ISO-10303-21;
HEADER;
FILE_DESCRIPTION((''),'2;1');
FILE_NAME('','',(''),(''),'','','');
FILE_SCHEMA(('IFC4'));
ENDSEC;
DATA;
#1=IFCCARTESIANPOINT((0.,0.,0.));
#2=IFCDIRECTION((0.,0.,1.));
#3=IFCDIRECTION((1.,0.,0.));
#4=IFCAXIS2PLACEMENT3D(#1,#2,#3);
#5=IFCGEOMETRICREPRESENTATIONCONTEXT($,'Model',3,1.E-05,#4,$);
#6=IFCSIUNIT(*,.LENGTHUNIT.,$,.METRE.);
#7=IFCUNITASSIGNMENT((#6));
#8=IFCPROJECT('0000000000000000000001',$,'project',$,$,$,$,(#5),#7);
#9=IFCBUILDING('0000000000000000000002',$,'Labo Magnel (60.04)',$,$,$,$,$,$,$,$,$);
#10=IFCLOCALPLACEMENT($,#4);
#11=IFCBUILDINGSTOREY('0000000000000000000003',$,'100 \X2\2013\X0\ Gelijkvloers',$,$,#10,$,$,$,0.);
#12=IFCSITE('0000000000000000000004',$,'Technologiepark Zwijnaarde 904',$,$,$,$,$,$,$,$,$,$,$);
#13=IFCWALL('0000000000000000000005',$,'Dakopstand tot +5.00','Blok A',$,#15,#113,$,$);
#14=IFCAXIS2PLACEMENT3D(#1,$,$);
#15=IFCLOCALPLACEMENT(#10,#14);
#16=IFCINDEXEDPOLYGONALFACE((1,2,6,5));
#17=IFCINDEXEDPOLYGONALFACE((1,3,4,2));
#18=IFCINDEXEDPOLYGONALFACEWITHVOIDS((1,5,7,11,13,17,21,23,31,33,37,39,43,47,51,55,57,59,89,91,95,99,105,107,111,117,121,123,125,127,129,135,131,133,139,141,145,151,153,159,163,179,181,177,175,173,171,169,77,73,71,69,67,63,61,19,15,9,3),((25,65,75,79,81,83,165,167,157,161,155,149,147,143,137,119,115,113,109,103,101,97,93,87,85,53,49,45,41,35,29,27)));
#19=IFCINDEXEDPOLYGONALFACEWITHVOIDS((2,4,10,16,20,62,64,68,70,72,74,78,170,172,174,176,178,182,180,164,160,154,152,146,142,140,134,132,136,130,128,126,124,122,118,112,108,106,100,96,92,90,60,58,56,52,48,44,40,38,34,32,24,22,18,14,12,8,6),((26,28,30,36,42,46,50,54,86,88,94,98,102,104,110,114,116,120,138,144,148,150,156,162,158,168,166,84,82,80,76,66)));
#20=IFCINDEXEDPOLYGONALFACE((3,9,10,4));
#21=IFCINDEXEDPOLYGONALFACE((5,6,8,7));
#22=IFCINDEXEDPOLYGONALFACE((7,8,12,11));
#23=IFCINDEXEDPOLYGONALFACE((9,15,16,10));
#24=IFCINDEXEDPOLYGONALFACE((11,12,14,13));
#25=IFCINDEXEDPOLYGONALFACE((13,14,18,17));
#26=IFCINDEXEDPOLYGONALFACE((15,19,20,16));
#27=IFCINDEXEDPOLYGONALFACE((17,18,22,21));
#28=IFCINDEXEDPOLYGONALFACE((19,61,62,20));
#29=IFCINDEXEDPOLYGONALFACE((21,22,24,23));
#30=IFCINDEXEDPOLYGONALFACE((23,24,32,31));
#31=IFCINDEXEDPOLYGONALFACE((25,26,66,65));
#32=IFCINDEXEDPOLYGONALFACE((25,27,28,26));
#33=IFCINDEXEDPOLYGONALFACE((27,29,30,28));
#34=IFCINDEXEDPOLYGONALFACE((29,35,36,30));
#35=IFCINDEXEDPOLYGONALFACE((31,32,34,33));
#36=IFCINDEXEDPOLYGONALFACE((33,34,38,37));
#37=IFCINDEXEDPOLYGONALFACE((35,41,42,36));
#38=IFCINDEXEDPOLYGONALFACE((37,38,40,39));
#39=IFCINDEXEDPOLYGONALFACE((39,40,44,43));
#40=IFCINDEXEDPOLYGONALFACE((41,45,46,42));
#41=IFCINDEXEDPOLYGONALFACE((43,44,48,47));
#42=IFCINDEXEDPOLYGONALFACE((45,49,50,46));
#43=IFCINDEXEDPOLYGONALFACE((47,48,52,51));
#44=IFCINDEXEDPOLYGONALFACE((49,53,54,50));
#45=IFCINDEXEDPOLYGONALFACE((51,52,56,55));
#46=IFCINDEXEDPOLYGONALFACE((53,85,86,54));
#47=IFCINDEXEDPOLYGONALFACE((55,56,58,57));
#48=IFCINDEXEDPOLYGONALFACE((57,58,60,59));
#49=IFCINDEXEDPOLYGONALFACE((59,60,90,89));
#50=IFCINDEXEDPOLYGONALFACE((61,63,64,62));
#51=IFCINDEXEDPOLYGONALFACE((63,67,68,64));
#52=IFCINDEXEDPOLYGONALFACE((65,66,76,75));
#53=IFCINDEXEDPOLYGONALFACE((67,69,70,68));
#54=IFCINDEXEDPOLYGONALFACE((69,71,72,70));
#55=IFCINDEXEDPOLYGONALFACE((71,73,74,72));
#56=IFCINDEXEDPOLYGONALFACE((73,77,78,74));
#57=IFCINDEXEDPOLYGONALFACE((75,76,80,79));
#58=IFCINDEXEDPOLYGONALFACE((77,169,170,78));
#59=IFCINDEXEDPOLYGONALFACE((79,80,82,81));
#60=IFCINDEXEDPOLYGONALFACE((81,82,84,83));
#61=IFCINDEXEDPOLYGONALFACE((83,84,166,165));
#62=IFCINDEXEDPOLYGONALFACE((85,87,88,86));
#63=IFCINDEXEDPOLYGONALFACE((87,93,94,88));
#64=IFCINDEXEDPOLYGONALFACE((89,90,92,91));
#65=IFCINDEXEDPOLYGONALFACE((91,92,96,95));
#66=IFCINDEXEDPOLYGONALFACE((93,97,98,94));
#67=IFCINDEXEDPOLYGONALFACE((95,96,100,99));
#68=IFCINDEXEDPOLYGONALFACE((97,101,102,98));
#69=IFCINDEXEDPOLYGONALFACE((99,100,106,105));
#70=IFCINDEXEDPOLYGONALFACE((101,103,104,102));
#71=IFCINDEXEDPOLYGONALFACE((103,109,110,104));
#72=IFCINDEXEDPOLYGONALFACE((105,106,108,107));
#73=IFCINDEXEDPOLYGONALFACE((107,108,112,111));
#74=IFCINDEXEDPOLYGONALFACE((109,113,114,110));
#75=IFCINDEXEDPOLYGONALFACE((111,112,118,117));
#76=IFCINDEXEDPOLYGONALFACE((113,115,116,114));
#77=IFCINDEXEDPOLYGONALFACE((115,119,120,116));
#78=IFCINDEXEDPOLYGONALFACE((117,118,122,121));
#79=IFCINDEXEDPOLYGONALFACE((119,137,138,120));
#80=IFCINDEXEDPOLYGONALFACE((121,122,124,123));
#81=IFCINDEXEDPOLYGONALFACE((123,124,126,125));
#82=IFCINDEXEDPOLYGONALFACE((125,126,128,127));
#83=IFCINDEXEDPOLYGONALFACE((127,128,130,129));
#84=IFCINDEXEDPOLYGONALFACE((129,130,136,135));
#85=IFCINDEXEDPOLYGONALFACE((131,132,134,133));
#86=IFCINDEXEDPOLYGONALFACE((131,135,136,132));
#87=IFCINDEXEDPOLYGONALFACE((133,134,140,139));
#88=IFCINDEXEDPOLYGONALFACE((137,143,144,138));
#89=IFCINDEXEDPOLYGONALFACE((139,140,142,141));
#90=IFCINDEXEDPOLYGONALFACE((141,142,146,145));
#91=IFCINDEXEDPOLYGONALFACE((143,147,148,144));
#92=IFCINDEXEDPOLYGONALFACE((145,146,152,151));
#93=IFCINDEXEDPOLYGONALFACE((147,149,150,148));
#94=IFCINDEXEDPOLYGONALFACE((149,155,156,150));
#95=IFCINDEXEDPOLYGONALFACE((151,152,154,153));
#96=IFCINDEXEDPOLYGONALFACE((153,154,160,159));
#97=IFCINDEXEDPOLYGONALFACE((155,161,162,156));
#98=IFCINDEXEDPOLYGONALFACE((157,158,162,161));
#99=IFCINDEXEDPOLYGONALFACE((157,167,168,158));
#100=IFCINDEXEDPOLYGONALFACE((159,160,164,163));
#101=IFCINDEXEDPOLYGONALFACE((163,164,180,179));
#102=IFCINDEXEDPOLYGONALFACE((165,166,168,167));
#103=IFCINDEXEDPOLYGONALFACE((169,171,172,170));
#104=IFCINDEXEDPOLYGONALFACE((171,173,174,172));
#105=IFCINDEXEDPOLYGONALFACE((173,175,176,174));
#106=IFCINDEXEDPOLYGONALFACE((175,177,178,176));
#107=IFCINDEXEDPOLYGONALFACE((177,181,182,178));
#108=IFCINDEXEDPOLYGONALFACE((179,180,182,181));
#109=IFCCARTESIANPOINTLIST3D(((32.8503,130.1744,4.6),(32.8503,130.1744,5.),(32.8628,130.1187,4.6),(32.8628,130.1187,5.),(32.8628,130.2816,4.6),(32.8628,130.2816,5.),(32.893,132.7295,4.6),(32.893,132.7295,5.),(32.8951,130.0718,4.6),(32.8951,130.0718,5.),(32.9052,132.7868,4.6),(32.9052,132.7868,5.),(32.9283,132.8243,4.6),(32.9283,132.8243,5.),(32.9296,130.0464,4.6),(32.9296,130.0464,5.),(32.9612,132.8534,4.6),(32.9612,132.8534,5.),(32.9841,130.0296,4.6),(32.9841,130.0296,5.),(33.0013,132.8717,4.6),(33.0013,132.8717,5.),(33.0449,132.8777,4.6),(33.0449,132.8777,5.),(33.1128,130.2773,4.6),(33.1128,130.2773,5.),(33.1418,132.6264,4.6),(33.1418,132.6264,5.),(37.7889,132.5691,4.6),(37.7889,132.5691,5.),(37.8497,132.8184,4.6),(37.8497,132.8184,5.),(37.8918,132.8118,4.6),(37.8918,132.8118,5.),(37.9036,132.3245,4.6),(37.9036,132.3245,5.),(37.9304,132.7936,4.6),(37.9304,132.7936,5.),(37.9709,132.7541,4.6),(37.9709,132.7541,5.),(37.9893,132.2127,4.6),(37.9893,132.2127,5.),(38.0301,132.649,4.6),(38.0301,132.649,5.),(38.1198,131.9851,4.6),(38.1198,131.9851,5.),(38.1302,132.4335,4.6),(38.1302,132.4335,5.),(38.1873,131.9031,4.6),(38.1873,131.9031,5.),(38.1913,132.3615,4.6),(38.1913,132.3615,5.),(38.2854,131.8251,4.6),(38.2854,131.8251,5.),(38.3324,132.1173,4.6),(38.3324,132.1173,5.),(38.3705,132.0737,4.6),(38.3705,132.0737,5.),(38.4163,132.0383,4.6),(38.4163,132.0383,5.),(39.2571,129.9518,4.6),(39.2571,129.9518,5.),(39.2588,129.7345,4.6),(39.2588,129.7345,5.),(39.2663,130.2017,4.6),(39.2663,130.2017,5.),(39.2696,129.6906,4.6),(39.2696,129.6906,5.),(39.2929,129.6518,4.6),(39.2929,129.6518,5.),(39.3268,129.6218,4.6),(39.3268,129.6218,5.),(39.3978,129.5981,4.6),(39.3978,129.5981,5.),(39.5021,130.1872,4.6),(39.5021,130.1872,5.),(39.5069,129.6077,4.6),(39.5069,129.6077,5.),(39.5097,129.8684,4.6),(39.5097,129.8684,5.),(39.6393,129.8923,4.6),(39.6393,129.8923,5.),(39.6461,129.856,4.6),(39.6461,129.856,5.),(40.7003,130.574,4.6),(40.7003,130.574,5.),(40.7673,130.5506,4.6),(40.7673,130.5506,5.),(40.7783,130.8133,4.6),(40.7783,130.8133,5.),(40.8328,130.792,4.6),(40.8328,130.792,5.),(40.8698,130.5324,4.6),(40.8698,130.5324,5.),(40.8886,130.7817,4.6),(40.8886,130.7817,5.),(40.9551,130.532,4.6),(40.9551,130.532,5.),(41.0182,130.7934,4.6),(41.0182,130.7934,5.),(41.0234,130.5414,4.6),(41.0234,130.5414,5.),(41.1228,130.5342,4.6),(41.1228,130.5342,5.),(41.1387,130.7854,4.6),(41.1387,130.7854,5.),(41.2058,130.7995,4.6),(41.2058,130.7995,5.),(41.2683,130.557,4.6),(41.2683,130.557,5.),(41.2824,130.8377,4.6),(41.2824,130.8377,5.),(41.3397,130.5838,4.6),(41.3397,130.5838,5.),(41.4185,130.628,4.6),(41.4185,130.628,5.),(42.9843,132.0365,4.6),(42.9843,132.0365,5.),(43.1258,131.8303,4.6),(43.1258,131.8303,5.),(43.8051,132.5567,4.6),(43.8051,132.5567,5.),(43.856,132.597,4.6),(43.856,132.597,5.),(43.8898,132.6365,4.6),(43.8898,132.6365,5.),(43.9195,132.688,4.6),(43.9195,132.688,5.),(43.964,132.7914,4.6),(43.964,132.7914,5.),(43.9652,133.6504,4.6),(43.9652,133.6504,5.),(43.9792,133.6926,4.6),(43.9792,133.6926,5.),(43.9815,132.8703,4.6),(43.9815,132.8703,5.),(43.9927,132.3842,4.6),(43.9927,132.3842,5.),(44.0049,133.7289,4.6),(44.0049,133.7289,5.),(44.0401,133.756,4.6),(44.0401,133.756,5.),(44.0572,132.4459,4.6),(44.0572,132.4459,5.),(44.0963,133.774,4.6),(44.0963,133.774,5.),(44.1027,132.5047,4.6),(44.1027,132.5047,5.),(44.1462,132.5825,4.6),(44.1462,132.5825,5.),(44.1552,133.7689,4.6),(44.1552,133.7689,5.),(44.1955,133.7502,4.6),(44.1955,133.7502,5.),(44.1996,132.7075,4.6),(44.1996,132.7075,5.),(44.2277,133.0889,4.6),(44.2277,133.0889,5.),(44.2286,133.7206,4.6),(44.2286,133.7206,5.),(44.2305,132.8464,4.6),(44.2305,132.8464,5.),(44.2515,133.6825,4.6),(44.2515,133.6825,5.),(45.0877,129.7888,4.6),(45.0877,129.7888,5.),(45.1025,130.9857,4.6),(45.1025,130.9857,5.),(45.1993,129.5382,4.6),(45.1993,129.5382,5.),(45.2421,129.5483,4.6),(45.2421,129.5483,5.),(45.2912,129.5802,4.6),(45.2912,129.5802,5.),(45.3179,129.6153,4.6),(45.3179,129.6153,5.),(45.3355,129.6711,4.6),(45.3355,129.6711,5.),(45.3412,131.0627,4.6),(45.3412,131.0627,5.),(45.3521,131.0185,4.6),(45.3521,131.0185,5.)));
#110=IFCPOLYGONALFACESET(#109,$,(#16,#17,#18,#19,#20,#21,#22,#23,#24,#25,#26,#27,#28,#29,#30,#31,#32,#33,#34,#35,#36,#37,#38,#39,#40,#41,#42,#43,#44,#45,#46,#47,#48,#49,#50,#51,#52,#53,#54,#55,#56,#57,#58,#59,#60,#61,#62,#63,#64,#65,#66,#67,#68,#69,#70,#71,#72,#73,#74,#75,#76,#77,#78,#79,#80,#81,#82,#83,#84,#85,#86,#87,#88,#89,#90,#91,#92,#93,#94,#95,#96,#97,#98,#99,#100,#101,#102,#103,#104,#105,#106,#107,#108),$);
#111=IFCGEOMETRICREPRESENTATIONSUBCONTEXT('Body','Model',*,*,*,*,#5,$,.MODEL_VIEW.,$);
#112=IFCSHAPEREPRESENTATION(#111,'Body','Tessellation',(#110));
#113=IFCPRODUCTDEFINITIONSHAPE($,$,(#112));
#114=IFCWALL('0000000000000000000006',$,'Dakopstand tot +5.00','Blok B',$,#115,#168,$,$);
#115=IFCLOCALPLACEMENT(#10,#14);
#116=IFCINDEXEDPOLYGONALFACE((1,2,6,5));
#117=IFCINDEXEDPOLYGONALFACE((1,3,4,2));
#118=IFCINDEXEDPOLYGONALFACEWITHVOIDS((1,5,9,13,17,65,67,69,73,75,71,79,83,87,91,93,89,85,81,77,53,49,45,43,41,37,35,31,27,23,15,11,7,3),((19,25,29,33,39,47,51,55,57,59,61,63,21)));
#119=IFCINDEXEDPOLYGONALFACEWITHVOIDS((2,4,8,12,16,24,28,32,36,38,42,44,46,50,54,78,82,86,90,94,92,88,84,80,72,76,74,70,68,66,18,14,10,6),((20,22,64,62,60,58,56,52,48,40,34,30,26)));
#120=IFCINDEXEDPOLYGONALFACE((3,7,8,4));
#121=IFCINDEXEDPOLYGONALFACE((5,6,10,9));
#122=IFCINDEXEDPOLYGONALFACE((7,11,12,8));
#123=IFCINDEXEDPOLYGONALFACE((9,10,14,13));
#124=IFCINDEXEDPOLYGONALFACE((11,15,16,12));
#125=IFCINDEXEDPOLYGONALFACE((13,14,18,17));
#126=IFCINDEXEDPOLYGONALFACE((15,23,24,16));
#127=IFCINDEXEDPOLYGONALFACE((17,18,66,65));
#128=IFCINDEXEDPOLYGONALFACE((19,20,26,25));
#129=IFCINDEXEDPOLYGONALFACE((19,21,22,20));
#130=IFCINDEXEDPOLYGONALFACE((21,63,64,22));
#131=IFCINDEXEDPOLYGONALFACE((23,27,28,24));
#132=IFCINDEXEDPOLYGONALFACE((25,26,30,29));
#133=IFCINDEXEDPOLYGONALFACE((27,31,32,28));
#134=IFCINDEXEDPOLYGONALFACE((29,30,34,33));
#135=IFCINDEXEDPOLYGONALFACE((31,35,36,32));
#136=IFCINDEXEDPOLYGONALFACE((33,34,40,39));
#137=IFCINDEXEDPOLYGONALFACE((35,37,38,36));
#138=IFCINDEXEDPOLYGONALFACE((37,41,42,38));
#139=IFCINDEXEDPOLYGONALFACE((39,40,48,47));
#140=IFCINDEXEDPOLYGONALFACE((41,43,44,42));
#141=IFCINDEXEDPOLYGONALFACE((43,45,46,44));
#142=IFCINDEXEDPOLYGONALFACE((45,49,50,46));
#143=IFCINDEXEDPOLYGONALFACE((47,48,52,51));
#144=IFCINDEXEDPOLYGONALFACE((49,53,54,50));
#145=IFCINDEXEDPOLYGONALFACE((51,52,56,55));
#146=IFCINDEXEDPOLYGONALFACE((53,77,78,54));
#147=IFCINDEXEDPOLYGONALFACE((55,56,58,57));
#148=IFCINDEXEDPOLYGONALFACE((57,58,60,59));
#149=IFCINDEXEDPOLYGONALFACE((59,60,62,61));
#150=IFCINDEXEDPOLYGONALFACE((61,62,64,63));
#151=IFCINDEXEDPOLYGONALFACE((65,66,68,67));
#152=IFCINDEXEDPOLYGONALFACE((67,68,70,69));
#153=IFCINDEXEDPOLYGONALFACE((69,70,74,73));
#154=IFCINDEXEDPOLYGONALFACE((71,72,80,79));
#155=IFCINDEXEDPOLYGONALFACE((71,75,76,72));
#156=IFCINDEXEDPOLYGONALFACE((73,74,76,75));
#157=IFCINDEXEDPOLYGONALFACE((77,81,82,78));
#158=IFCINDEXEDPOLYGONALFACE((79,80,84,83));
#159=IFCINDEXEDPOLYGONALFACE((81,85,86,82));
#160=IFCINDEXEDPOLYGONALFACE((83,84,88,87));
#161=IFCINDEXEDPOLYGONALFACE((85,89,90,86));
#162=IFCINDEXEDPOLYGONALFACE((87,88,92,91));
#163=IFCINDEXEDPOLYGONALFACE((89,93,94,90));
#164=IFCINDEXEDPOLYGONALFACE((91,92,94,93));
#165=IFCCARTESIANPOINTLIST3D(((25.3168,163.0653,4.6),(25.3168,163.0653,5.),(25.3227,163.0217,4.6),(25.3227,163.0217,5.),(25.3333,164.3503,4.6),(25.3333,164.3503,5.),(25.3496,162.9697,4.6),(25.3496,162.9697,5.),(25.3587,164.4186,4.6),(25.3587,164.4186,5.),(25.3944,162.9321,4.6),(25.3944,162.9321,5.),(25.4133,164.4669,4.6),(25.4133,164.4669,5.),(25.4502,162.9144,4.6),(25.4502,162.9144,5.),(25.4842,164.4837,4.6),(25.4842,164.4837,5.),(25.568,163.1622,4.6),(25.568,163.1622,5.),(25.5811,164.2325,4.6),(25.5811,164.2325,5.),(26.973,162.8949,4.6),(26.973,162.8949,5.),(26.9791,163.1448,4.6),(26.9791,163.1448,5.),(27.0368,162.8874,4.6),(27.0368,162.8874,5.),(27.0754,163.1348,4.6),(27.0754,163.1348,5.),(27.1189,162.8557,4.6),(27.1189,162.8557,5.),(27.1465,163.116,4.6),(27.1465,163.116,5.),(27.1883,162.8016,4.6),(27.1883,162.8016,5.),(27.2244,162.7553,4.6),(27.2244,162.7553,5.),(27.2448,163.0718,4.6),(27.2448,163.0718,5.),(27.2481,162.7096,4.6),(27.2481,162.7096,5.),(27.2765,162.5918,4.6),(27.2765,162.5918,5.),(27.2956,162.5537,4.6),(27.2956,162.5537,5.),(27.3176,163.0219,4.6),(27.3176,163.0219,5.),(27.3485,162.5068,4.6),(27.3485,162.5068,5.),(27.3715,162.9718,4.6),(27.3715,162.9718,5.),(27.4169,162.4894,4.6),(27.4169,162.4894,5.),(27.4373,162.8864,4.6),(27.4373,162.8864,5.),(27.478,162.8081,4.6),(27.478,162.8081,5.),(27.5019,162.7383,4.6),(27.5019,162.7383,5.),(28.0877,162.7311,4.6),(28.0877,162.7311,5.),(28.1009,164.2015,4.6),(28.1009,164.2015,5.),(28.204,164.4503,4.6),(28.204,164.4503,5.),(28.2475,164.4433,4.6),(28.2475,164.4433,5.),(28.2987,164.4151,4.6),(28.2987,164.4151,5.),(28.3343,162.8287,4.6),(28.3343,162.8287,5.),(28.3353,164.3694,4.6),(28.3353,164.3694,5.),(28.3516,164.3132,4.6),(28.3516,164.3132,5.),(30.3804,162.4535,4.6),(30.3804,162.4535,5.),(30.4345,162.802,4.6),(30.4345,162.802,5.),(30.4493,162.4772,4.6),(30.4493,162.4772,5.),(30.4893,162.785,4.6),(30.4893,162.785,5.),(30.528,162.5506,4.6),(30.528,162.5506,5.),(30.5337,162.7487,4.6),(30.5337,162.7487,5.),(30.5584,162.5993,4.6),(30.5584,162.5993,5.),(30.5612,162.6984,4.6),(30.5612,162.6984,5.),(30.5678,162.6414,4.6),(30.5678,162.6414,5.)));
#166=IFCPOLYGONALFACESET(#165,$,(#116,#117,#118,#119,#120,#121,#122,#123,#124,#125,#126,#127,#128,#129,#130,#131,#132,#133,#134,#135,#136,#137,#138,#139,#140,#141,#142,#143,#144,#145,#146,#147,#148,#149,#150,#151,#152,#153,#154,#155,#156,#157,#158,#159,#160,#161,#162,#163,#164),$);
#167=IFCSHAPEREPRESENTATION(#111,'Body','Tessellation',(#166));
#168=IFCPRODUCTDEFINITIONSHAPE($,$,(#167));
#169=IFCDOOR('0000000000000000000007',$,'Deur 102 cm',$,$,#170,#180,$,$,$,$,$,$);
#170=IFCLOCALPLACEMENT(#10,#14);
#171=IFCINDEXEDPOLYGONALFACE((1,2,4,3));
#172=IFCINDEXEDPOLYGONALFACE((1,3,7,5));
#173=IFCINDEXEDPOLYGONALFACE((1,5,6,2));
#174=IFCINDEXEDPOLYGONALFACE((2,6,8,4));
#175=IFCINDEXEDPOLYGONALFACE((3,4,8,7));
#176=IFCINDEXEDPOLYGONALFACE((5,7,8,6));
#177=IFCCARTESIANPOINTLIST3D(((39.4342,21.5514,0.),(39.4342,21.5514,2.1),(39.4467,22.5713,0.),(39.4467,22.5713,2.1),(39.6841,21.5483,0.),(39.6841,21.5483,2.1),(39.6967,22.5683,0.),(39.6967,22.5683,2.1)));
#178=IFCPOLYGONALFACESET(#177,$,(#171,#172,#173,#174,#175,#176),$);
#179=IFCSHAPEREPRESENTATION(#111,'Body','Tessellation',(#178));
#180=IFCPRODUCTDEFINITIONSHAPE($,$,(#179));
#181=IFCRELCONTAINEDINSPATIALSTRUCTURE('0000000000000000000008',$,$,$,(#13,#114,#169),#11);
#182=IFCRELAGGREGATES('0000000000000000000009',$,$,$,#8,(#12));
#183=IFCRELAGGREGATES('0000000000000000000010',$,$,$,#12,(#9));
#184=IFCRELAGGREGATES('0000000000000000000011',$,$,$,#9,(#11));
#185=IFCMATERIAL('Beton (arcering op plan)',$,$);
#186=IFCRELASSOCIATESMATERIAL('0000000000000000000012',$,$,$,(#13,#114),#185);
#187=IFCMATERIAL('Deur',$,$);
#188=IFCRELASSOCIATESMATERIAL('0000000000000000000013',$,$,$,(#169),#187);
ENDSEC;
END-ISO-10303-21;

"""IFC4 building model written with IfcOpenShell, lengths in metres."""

from ifc_helpers import new_model, si_unit, frame, origin, origin_with_axes, place, context, subcontext, project, spatial, polyline, outline, extrude, material, element, save


model = new_model("IFC4")

# Units and contexts
model_context = context("Model", 3, precision=1e-05, world=origin_with_axes())
body_context = subcontext(model_context, "Body", "Model", "MODEL_VIEW")
ifc_project = project(units=[si_unit("LENGTHUNIT", "METRE")], contexts=[model_context])

# Site, building, storey
site = spatial("IfcSite", under=ifc_project, Name="Technologiepark Zwijnaarde 904")
building = spatial("IfcBuilding", under=site, Name="Labo Magnel (60.04)")
storey_placement = place(None, origin_with_axes())
storey = spatial("IfcBuildingStorey", under=building, at=storey_placement, Name="100 – Gelijkvloers", Elevation=0.0)

# Shared definitions
ifc_material_1 = material(Name="Beton (arcering op plan)")

# Walls
wall_1_placement = place(storey_placement, frame((0.0, 0.0, 4.6), z_axis=(0.0, 0.0, 1.0), x_axis=(1.0, 0.0, 0.0)))
element("IfcWall", 1, at=wall_1_placement, inside=storey, material=ifc_material_1, Name="Dakopstand tot +5.00", Description="Blok A", context=body_context, shape_type="SweptSolid", body=[
    extrude(outline(polyline([(32.9841, 130.0296), (32.9296, 130.0464), (32.8951, 130.0718), (32.8628, 130.1187), (32.8503, 130.1744), (32.8628, 130.2816), (32.893, 132.7295), (32.9052, 132.7868), (32.9283, 132.8243), (32.9612, 132.8534), (33.0013, 132.8717), (33.0449, 132.8777), (37.8497, 132.8184), (37.8918, 132.8118), (37.9304, 132.7936), (37.9709, 132.7541), (38.0301, 132.649), (38.1302, 132.4335), (38.1913, 132.3615), (38.3324, 132.1173), (38.3705, 132.0737), (38.4163, 132.0383), (40.7783, 130.8133), (40.8328, 130.792), (40.8886, 130.7817), (41.0182, 130.7934), (41.1387, 130.7854), (41.2058, 130.7995), (41.2824, 130.8377), (42.9843, 132.0365), (43.8051, 132.5567), (43.856, 132.597), (43.8898, 132.6365), (43.9195, 132.688), (43.964, 132.7914), (43.9815, 132.8703), (43.9652, 133.6504), (43.9792, 133.6926), (44.0049, 133.7289), (44.0401, 133.756), (44.0963, 133.774), (44.1552, 133.7689), (44.1955, 133.7502), (44.2286, 133.7206), (44.2515, 133.6825), (45.3412, 131.0627), (45.3521, 131.0185), (45.3355, 129.6711), (45.3179, 129.6153), (45.2912, 129.5802), (45.2421, 129.5483), (45.1993, 129.5382), (39.5069, 129.6077), (39.3978, 129.5981), (39.3268, 129.6218), (39.2929, 129.6518), (39.2696, 129.6906), (39.2588, 129.7345), (39.2571, 129.9518), (32.9841, 130.0296)]), holes=[polyline([(39.2663, 130.2017), (39.5021, 130.1872), (39.5097, 129.8684), (39.6393, 129.8923), (39.6461, 129.856), (45.0877, 129.7888), (45.1025, 130.9857), (44.2277, 133.0889), (44.2305, 132.8464), (44.1996, 132.7075), (44.1462, 132.5825), (44.1027, 132.5047), (44.0572, 132.4459), (43.9927, 132.3842), (43.1258, 131.8303), (41.4185, 130.628), (41.3397, 130.5838), (41.2683, 130.557), (41.1228, 130.5342), (41.0234, 130.5414), (40.9551, 130.532), (40.8698, 130.5324), (40.7673, 130.5506), (40.7003, 130.574), (38.2854, 131.8251), (38.1873, 131.9031), (38.1198, 131.9851), (37.9893, 132.2127), (37.9036, 132.3245), (37.7889, 132.5691), (33.1418, 132.6264), (33.1128, 130.2773), (39.2663, 130.2017)])]), origin(), (0.0, 0.0, 1.0), 0.4),
])
wall_2_placement = place(storey_placement, frame((0.0, 0.0, 4.6), z_axis=(0.0, 0.0, 1.0), x_axis=(1.0, 0.0, 0.0)))
element("IfcWall", 2, at=wall_2_placement, inside=storey, material=ifc_material_1, Name="Dakopstand tot +5.00", Description="Blok B", context=body_context, shape_type="SweptSolid", body=[
    extrude(outline(polyline([(25.4502, 162.9144), (25.3944, 162.9321), (25.3496, 162.9697), (25.3227, 163.0217), (25.3168, 163.0653), (25.3333, 164.3503), (25.3587, 164.4186), (25.4133, 164.4669), (25.4842, 164.4837), (28.204, 164.4503), (28.2475, 164.4433), (28.2987, 164.4151), (28.3353, 164.3694), (28.3516, 164.3132), (28.3343, 162.8287), (30.4345, 162.802), (30.4893, 162.785), (30.5337, 162.7487), (30.5612, 162.6984), (30.5678, 162.6414), (30.5584, 162.5993), (30.528, 162.5506), (30.4493, 162.4772), (30.3804, 162.4535), (27.4169, 162.4894), (27.3485, 162.5068), (27.2956, 162.5537), (27.2765, 162.5918), (27.2481, 162.7096), (27.2244, 162.7553), (27.1883, 162.8016), (27.1189, 162.8557), (27.0368, 162.8874), (26.973, 162.8949), (25.4502, 162.9144)]), holes=[polyline([(26.9791, 163.1448), (27.0754, 163.1348), (27.1465, 163.116), (27.2448, 163.0718), (27.3176, 163.0219), (27.3715, 162.9718), (27.4373, 162.8864), (27.478, 162.8081), (27.5019, 162.7383), (28.0877, 162.7311), (28.1009, 164.2015), (25.5811, 164.2325), (25.568, 163.1622), (26.9791, 163.1448)])]), origin(), (0.0, 0.0, 1.0), 0.4),
])

# Door
ifc_material_2 = material(Name="Deur")
door_placement = place(storey_placement, frame((39.5717, 22.5698, 0.0), z_axis=(0.0, 0.0, 1.0), x_axis=(-0.012293, -0.999924, 0.0)))
element("IfcDoor", 3, at=door_placement, inside=storey, material=ifc_material_2, Name="Deur 102 cm", context=body_context, shape_type="SweptSolid", body=[
    extrude(outline(polyline([(0.0, -0.125), (1.02, -0.125), (1.02, 0.125), (0.0, 0.125), (0.0, -0.125)])), origin(), (0.0, 0.0, 1.0), 2.1),
])

save(model, "model.ifc")
